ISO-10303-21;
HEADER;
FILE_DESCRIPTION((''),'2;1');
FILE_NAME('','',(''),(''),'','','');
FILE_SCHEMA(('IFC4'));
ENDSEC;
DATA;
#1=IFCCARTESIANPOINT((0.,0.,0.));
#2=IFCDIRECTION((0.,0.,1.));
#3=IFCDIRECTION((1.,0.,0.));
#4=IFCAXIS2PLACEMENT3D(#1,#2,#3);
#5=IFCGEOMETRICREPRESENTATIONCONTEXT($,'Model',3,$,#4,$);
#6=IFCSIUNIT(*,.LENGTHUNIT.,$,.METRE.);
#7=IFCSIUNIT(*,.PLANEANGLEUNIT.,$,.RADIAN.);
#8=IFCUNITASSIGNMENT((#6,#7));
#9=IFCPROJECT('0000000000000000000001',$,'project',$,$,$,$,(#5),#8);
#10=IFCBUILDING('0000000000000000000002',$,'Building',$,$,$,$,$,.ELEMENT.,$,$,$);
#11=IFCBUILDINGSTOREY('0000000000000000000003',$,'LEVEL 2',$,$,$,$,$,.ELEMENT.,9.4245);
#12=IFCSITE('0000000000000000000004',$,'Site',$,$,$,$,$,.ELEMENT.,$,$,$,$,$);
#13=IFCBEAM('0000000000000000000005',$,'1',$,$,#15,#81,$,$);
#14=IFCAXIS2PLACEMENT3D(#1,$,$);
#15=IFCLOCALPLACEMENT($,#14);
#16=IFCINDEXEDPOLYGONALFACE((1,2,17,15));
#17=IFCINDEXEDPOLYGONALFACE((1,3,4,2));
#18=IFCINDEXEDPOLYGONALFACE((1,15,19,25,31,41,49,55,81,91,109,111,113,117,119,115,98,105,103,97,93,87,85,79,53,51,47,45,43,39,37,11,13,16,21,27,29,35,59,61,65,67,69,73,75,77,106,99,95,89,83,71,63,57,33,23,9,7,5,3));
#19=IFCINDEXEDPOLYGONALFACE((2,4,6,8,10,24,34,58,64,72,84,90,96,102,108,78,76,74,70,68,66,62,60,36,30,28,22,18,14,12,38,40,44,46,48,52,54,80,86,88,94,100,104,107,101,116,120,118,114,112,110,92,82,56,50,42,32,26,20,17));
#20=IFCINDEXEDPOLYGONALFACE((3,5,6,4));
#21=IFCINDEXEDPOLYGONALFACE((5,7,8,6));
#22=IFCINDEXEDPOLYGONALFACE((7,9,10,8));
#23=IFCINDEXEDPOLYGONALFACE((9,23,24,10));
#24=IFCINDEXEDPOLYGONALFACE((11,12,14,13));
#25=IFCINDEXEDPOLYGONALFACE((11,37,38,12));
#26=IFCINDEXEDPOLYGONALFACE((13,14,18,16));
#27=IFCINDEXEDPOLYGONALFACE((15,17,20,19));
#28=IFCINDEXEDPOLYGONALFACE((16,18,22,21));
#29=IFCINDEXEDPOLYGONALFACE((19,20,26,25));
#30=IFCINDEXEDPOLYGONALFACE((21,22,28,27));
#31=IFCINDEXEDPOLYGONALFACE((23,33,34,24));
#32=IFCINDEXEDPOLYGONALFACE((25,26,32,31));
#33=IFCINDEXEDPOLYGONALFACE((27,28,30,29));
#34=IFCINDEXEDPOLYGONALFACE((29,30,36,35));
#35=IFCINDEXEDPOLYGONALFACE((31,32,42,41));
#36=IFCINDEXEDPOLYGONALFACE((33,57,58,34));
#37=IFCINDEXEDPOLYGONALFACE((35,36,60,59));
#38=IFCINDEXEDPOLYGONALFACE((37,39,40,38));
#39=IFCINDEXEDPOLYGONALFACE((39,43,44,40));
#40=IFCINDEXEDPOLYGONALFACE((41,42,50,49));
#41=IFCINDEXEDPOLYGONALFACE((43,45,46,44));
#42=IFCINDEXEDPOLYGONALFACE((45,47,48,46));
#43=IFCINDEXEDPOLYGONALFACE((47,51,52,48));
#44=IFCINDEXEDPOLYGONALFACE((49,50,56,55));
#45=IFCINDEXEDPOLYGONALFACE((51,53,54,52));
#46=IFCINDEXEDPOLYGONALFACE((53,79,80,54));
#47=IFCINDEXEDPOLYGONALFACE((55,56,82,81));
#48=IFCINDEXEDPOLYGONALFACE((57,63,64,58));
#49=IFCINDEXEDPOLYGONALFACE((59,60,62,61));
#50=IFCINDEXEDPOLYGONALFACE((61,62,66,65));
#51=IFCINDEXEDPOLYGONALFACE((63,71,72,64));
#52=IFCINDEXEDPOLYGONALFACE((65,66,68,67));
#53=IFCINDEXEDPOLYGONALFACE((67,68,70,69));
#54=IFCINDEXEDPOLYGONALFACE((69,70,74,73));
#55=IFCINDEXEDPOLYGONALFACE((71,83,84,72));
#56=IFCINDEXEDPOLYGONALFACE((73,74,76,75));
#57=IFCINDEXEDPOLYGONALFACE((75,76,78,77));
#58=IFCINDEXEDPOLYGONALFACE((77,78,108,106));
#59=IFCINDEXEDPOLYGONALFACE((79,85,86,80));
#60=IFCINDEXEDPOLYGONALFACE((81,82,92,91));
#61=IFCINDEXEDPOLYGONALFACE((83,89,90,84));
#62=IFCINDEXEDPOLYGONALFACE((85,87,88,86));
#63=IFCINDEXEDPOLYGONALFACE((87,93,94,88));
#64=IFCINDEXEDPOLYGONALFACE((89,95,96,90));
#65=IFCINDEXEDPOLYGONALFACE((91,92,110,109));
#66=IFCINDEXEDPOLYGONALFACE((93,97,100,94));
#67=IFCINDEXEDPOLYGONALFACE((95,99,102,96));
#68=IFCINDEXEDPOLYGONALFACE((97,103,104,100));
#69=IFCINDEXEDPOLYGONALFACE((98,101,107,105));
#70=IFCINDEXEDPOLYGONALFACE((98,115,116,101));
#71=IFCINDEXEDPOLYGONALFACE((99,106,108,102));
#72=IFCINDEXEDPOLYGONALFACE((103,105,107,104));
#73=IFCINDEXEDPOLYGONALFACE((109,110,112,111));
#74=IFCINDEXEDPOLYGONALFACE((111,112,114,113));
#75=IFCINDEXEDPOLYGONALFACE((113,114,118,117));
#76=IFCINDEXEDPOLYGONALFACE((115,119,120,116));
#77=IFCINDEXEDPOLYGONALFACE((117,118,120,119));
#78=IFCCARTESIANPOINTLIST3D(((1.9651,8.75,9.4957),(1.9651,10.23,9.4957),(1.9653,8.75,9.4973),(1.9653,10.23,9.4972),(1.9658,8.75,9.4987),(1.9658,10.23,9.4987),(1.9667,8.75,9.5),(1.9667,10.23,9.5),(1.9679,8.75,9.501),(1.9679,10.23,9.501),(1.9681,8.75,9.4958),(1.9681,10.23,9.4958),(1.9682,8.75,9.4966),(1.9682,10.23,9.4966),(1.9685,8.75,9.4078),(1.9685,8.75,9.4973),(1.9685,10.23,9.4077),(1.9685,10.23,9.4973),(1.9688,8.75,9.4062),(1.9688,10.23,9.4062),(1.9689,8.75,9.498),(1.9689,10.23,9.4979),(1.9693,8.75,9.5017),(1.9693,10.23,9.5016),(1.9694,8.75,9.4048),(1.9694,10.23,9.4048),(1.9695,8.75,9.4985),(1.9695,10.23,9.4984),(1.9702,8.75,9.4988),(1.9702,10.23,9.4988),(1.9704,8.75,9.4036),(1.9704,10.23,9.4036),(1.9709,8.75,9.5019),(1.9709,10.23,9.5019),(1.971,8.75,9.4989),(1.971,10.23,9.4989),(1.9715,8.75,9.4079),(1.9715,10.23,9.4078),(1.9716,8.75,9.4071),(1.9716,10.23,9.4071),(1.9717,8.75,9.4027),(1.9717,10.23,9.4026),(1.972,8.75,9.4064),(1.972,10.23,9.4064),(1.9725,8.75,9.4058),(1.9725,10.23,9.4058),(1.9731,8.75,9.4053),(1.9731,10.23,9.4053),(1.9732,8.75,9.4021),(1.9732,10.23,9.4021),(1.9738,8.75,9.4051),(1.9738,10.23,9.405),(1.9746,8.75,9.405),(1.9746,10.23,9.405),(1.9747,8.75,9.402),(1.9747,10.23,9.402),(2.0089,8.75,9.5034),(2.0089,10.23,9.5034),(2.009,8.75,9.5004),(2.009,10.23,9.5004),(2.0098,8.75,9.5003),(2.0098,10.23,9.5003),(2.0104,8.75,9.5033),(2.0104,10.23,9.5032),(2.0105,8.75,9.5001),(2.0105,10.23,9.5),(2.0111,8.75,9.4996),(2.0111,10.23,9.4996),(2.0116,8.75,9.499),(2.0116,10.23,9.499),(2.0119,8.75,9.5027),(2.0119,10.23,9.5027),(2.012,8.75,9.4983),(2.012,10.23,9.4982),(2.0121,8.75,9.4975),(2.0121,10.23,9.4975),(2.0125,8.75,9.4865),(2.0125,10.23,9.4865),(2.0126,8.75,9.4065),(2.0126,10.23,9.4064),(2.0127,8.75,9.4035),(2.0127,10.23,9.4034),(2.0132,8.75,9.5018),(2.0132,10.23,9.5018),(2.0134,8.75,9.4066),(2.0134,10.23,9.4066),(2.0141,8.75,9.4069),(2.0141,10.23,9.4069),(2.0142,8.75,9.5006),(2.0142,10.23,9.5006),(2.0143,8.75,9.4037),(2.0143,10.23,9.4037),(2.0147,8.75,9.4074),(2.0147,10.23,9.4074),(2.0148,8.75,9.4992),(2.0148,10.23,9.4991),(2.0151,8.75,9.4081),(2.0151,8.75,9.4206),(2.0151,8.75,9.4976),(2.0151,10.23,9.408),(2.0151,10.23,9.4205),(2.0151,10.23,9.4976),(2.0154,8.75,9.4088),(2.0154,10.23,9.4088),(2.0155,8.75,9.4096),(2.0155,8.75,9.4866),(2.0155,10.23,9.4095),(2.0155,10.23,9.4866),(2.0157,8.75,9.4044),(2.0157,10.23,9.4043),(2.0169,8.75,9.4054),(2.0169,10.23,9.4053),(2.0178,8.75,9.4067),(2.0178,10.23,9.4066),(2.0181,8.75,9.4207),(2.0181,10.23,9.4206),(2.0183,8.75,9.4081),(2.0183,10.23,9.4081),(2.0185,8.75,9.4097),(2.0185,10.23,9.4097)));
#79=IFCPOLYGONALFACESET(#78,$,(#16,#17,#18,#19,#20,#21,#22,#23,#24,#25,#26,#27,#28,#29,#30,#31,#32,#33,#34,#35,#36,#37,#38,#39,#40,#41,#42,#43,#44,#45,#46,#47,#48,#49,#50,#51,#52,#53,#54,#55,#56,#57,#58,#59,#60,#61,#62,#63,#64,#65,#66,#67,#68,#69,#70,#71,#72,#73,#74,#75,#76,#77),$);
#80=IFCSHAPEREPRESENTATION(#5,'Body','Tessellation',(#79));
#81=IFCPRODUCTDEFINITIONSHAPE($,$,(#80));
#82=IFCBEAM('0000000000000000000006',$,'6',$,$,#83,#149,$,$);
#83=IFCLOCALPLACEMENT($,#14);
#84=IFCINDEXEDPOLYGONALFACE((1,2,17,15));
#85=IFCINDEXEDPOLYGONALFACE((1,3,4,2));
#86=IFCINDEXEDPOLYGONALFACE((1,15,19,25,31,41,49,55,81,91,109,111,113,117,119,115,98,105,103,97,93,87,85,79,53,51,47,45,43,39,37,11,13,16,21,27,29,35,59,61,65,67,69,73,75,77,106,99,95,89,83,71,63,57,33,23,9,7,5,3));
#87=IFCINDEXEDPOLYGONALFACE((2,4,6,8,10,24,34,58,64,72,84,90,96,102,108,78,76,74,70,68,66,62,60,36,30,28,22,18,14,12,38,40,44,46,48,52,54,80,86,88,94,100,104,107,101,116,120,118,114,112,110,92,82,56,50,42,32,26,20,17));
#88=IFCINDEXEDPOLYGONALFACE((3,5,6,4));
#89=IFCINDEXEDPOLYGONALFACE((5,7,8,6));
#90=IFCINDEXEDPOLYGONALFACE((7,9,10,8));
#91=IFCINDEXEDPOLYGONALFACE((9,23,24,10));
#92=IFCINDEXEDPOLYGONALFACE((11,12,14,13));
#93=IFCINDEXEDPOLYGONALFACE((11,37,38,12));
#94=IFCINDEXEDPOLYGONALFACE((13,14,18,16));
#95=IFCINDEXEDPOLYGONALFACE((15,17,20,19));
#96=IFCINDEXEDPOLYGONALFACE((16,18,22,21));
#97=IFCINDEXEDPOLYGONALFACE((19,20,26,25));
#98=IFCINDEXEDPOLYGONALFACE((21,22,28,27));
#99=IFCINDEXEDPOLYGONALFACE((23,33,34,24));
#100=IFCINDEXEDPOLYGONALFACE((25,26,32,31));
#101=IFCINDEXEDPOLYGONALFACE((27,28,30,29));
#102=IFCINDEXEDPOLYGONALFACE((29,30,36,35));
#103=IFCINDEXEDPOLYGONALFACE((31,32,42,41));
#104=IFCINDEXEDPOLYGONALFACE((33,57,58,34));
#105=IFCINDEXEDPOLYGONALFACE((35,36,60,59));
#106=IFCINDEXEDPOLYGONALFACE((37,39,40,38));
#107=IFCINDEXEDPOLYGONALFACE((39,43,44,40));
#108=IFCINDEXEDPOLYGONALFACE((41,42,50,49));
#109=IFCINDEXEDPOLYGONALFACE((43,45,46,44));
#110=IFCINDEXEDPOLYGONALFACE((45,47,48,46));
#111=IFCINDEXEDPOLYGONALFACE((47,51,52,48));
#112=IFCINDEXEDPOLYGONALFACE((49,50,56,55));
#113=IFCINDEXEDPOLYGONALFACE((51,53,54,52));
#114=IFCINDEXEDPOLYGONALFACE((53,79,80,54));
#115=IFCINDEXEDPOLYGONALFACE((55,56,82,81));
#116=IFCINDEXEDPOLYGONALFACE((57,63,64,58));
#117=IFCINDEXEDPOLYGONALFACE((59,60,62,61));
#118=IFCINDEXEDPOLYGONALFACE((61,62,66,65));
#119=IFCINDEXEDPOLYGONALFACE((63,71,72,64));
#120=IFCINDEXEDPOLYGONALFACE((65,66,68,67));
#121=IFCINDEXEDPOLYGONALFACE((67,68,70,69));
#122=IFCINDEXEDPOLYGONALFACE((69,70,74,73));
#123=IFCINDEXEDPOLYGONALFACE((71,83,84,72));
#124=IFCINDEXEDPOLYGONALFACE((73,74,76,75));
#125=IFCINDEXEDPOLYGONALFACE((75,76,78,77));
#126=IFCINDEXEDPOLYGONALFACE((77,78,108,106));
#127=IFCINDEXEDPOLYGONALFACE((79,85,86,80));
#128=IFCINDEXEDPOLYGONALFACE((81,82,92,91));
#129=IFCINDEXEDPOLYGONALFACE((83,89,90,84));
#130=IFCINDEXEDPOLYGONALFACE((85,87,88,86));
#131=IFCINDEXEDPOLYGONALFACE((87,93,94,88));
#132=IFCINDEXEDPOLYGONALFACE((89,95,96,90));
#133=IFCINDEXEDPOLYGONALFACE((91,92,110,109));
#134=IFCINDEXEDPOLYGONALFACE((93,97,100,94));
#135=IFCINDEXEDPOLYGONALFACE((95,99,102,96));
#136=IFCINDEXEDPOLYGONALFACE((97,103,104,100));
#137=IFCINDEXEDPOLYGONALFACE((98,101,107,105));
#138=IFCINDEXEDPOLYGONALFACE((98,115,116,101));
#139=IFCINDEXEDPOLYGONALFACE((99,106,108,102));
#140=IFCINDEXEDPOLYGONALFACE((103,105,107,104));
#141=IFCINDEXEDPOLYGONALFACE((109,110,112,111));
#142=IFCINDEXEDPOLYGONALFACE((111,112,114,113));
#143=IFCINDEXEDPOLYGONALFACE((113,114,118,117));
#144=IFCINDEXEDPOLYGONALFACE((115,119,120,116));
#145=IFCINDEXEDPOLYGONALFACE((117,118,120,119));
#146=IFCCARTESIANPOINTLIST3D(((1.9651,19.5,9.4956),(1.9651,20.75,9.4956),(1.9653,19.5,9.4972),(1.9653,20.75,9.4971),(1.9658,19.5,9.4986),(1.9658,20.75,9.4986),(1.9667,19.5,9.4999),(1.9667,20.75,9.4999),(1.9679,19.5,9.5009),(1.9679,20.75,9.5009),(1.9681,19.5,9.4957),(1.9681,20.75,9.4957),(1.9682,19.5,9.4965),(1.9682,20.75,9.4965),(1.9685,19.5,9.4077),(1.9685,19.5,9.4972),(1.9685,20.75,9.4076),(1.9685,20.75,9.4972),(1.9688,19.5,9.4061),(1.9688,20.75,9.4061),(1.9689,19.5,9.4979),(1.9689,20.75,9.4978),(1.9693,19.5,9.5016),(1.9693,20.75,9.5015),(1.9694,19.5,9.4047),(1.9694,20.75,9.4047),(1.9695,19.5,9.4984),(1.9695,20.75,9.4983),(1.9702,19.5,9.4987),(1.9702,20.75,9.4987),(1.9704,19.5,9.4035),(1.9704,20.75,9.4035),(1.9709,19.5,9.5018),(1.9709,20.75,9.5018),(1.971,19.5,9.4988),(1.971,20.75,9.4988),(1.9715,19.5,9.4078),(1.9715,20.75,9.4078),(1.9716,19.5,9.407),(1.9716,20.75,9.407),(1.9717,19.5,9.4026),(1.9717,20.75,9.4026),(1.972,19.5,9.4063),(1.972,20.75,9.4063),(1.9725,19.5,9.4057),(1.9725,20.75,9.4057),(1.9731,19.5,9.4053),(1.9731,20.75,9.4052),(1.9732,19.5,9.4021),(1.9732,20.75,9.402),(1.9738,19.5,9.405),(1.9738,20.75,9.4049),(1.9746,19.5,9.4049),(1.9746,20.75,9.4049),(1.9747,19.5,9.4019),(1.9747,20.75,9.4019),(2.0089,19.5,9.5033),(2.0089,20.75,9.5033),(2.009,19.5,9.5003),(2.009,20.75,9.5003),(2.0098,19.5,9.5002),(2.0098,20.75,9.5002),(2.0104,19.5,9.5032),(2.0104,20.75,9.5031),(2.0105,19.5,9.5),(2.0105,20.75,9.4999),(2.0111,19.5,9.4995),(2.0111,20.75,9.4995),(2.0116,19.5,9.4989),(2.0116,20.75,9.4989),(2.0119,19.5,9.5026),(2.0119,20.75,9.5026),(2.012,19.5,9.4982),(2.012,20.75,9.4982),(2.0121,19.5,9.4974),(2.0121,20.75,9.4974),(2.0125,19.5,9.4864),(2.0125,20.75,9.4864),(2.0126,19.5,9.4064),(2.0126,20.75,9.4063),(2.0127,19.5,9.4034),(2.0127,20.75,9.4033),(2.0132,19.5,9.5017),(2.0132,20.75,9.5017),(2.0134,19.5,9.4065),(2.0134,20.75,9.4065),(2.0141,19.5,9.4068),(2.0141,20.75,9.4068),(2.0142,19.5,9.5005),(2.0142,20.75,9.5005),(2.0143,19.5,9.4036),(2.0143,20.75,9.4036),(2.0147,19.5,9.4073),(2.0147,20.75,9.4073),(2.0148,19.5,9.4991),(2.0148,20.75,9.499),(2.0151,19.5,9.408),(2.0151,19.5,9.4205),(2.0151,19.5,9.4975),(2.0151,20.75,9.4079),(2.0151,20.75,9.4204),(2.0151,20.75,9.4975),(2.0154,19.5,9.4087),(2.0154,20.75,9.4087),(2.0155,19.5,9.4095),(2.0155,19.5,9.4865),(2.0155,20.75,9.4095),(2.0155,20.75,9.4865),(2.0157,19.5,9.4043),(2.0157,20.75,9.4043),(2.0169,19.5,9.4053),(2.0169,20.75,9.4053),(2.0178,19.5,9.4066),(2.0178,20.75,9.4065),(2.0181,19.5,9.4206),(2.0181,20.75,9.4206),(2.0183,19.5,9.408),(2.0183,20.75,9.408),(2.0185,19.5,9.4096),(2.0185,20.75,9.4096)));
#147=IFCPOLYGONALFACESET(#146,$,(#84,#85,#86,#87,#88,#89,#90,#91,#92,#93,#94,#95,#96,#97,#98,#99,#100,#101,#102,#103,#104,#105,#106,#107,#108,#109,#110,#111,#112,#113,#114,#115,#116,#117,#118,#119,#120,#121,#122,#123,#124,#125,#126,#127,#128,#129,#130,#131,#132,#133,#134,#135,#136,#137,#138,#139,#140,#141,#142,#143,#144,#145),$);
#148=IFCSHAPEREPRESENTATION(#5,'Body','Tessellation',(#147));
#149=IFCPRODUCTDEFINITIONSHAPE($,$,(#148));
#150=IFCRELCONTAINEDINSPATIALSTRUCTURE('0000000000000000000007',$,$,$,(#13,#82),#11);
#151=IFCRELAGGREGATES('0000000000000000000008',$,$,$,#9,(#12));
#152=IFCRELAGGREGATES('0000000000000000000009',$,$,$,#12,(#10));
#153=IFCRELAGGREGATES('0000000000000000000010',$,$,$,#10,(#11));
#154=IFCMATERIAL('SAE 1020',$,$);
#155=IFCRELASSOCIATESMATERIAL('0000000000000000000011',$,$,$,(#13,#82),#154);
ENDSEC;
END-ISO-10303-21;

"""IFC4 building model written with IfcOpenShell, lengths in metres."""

from ifc_helpers import new_model, si_unit, frame, origin_with_axes, origin_2d_with_axis, place, context, project, spatial, c_section, extrude, material, material_profile, profile_set, profile_usage, element, save


model = new_model("IFC4")

# Units and contexts
model_context = context("Model", 3, world=origin_with_axes())
ifc_project = project(units=[si_unit("LENGTHUNIT", "METRE"), si_unit("PLANEANGLEUNIT", "RADIAN")], contexts=[model_context])

# Site, building, storey
site = spatial("IfcSite", under=ifc_project, Name="Site", CompositionType="ELEMENT")
building = spatial("IfcBuilding", under=site, Name="Building", CompositionType="ELEMENT")
storey = spatial("IfcBuildingStorey", under=building, Name="LEVEL 2", CompositionType="ELEMENT", Elevation=9.4245)

# Beams
ifc_material = material(Name="SAE 1020")
ifc_material_profile_1 = material_profile(ifc_material, c_section(Depth=0.1, Width=0.05, WallThickness=0.003, Girth=0.017, InternalFilletRadius=0.003, at=origin_2d_with_axis()))
ifc_profile_set_1 = profile_set([ifc_material_profile_1])
ifc_profile_usage_1 = profile_usage(ifc_profile_set_1, cardinal=10)
beam_1_placement = place(None, frame((1.9918, 8.75, 9.4527), z_axis=(0.0, 1.0, -0.00003), x_axis=(0.999256, 0.000001, 0.038562)))
element("IfcBeam", 1, at=beam_1_placement, inside=storey, material=ifc_profile_usage_1, Name="1", context=model_context, shape_type="SweptSolid", body=[
    extrude(c_section(Depth=0.1, Width=0.05, WallThickness=0.003, Girth=0.017, InternalFilletRadius=0.003, at=origin_2d_with_axis()), origin_with_axes(), (0.0, 0.0, 1.0), 1.48),
])
ifc_material_profile_2 = material_profile(ifc_material, c_section(Depth=0.1, Width=0.05, WallThickness=0.003, Girth=0.017, InternalFilletRadius=0.003, at=origin_2d_with_axis()))
ifc_profile_set_2 = profile_set([ifc_material_profile_2])
ifc_profile_usage_2 = profile_usage(ifc_profile_set_2, cardinal=10)
beam_2_placement = place(None, frame((1.9918, 19.5, 9.4526), z_axis=(0.0, 1.0, -0.00003), x_axis=(0.999256, 0.000001, 0.038562)))
element("IfcBeam", 2, at=beam_2_placement, inside=storey, material=ifc_profile_usage_2, Name="6", context=model_context, shape_type="SweptSolid", body=[
    extrude(c_section(Depth=0.1, Width=0.05, WallThickness=0.003, Girth=0.017, InternalFilletRadius=0.003, at=origin_2d_with_axis()), origin_with_axes(), (0.0, 0.0, 1.0), 1.25),
])

save(model, "model.ifc")
